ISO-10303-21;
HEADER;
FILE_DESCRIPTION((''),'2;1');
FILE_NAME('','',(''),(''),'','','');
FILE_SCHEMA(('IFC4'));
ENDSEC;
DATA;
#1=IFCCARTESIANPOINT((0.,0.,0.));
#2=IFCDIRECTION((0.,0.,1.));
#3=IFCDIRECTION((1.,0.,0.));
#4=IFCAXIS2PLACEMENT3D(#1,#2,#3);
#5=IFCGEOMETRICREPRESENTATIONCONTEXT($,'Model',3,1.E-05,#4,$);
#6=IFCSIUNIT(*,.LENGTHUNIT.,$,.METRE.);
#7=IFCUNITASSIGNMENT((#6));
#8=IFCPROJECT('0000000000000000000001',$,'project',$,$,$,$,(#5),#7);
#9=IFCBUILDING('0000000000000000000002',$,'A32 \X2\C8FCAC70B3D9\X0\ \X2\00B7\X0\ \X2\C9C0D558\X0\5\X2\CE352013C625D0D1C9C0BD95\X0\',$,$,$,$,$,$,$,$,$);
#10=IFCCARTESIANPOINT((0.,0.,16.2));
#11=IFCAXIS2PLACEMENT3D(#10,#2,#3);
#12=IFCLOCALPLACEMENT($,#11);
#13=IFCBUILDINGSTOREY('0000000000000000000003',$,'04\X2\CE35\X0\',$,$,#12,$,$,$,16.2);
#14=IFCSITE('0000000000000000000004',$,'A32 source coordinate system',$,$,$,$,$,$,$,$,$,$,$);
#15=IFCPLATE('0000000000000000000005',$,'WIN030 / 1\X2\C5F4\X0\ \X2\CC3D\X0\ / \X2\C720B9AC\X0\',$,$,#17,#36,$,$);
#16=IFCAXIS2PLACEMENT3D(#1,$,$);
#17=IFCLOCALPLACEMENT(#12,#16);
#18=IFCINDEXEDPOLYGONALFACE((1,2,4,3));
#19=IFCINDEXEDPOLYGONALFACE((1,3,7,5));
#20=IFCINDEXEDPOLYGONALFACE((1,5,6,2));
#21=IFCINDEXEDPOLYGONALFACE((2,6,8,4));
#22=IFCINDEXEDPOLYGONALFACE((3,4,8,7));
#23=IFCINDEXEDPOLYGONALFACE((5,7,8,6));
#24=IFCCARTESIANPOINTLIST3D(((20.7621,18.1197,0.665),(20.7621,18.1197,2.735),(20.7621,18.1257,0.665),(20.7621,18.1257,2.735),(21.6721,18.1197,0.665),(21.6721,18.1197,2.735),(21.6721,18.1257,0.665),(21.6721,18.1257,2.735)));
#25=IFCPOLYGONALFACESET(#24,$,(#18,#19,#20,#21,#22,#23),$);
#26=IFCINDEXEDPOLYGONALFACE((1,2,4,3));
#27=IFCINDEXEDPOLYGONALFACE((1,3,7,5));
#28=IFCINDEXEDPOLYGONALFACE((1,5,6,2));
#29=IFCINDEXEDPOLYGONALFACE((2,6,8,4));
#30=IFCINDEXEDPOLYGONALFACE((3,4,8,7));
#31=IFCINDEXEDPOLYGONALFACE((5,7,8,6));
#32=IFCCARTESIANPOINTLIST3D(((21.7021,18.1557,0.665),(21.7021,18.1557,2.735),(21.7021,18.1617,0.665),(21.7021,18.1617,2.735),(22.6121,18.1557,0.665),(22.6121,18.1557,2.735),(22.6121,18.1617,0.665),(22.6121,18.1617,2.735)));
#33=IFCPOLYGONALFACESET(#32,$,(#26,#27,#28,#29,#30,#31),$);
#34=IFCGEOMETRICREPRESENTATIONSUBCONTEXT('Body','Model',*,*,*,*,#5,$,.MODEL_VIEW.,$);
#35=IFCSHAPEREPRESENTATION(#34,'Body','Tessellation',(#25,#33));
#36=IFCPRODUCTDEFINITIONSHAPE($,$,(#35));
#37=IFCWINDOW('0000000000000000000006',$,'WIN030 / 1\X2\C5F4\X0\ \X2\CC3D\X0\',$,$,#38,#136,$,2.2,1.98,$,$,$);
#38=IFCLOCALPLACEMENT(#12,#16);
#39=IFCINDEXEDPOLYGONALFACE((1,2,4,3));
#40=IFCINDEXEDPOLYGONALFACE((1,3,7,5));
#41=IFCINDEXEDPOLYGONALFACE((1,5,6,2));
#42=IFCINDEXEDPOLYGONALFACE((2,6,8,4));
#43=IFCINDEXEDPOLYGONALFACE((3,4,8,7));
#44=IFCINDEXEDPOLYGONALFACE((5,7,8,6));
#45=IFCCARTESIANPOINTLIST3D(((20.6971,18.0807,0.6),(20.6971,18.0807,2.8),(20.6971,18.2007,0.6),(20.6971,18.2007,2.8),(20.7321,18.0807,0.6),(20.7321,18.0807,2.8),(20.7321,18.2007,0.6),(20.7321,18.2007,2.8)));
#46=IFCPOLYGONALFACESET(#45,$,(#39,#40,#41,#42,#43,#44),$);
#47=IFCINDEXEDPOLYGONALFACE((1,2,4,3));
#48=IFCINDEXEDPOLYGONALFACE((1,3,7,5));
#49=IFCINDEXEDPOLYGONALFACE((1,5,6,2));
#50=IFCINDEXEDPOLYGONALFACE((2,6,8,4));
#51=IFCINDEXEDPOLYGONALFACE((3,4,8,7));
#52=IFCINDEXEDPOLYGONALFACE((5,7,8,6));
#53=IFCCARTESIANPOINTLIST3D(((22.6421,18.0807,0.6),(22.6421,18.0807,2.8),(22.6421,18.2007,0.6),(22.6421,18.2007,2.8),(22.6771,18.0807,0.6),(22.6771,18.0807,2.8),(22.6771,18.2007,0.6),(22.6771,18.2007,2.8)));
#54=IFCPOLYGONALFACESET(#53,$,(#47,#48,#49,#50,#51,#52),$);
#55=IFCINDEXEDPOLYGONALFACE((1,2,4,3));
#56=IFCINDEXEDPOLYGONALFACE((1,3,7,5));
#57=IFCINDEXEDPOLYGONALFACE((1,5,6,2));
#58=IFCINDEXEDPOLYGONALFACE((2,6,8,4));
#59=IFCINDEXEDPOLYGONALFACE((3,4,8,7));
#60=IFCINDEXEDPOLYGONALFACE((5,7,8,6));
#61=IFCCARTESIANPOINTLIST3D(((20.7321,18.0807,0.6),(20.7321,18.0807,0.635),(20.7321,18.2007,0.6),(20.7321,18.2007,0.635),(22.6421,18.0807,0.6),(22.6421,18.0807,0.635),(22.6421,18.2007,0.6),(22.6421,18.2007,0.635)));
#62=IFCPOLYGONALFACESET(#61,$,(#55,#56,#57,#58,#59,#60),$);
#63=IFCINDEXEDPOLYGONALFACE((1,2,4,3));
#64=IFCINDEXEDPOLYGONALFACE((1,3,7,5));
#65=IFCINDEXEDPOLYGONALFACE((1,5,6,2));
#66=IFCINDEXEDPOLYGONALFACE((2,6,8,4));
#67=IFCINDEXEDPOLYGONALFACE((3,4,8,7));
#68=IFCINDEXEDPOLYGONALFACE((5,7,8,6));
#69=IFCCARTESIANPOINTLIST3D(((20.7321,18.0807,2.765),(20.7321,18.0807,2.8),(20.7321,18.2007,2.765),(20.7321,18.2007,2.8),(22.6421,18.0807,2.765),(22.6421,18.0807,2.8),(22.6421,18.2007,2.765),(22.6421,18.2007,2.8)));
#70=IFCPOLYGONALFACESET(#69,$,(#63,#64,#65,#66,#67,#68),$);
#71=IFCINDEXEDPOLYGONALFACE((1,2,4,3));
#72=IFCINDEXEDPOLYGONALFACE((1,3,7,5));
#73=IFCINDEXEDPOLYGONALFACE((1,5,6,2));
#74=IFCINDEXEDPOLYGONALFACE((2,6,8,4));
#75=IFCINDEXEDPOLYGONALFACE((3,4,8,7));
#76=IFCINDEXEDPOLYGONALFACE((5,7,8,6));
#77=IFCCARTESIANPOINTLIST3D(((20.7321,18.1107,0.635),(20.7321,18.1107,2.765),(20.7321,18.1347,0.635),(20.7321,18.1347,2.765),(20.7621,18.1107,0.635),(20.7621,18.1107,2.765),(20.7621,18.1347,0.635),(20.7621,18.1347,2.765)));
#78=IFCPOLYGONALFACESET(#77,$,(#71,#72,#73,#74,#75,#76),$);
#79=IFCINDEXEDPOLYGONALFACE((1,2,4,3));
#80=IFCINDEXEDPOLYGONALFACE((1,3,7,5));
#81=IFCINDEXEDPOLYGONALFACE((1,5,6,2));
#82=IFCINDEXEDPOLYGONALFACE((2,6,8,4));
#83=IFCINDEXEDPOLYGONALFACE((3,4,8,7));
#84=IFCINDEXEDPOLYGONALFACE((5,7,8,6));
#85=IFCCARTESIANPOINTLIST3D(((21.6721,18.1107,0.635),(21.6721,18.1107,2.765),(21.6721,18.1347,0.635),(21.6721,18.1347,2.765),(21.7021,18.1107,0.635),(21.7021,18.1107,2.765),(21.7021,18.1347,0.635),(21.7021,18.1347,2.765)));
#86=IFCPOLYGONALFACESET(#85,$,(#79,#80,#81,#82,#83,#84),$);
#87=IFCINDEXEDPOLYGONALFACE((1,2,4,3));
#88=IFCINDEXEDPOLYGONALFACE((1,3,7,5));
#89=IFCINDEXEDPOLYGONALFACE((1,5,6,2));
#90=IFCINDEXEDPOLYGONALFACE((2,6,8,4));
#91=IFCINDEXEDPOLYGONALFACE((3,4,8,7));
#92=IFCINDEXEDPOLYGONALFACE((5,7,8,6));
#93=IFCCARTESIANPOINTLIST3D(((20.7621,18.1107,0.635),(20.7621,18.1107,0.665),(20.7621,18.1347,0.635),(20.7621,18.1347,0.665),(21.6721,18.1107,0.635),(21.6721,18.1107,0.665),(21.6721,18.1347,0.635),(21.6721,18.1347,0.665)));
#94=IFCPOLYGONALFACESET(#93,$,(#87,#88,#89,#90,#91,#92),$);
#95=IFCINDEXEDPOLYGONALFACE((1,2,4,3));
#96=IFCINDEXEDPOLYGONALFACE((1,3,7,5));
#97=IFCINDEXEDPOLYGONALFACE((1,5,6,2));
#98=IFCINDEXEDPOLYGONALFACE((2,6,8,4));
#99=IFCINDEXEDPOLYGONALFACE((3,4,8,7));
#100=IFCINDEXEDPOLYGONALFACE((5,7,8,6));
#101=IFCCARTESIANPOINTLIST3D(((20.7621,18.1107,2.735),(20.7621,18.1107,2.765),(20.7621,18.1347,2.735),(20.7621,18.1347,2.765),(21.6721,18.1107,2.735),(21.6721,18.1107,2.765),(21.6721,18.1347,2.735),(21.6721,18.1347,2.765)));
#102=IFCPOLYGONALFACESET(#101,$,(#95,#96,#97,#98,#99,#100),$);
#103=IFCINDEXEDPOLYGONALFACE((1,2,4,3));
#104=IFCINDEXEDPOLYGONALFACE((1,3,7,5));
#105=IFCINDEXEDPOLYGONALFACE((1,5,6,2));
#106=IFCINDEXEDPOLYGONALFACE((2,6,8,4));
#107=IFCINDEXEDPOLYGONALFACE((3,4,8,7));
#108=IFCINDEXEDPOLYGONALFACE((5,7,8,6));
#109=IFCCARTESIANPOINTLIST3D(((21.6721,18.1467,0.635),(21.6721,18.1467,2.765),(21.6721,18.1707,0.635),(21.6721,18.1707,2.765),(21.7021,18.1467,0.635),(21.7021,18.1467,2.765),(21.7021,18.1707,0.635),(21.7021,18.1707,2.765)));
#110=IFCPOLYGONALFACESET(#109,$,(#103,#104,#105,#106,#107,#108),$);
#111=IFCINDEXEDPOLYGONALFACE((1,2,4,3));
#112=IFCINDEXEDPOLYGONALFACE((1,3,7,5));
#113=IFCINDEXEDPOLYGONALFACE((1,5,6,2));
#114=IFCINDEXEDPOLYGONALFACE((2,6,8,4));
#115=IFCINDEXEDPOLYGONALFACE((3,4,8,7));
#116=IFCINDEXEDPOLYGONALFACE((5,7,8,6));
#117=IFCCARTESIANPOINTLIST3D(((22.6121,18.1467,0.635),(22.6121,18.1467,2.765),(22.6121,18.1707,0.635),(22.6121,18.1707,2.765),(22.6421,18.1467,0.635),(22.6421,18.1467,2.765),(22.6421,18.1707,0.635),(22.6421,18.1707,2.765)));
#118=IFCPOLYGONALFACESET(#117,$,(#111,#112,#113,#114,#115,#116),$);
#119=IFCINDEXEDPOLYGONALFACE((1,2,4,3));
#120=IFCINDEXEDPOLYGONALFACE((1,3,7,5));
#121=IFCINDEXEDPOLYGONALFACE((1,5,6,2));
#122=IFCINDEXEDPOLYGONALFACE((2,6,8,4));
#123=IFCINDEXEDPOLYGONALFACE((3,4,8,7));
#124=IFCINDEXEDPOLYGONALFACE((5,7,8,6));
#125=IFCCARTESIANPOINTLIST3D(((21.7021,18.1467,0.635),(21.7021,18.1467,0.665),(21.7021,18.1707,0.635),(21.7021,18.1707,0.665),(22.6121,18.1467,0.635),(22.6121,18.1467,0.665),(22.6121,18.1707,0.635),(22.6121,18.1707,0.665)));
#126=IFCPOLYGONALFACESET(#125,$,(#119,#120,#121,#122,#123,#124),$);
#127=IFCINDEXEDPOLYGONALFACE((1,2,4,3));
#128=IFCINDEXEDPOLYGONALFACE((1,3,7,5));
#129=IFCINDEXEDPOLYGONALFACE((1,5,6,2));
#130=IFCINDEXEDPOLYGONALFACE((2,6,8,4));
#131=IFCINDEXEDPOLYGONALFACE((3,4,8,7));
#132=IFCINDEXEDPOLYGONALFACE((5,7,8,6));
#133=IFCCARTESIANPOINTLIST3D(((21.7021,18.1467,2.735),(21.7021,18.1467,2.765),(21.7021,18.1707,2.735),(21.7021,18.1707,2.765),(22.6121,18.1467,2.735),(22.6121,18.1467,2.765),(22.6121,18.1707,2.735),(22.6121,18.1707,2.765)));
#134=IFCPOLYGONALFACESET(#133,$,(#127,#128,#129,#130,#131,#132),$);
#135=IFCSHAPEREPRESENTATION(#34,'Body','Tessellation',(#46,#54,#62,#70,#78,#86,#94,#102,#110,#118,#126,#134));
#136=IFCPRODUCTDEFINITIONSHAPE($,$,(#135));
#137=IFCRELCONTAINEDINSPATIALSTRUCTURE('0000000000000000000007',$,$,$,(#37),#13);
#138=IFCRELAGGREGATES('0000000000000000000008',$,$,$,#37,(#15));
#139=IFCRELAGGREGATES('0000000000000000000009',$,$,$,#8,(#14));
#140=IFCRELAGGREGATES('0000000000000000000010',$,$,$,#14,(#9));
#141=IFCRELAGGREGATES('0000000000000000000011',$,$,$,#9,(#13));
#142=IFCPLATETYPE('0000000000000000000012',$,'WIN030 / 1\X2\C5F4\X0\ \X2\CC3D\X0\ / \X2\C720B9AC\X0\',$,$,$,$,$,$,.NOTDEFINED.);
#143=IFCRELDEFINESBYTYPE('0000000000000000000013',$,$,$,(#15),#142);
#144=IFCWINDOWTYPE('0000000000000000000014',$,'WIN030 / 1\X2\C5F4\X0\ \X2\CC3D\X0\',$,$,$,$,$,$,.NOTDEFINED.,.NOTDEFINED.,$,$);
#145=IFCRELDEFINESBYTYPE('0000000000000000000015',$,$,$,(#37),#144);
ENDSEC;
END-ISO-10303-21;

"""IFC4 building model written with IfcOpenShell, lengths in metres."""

from ifc_helpers import new_model, si_unit, frame, origin, origin_with_axes, place, context, subcontext, project, spatial, polyline, outline, extrude, source, transform, mapped, type_object, type_shapes, element, aggregate, save


model = new_model("IFC4")

# Units and contexts
model_context = context("Model", 3, precision=1e-05, world=origin_with_axes())
body_context = subcontext(model_context, "Body", "Model", "MODEL_VIEW")
ifc_project = project(units=[si_unit("LENGTHUNIT", "METRE")], contexts=[model_context])

# Plate
storey_placement = place(None, frame((0.0, 0.0, 16.2), z_axis=(0.0, 0.0, 1.0), x_axis=(1.0, 0.0, 0.0)))
plate_type_1 = type_object("IfcPlateType", Name="WIN030 / 1열 창 / 유리", PredefinedType="NOTDEFINED")
shared_shape_1 = source(origin(), body_context, "Body", "SweptSolid", [
    extrude(outline(polyline([(20.7621, 18.1197), (20.7621, 18.1257), (21.6721, 18.1257), (21.6721, 18.1197), (20.7621, 18.1197)])), frame((0.0, 0.0, 0.665)), (0.0, 0.0, 1.0), 2.07),
    extrude(outline(polyline([(21.7021, 18.1557), (21.7021, 18.1617), (22.6121, 18.1617), (22.6121, 18.1557), (21.7021, 18.1557)])), frame((0.0, 0.0, 0.665)), (0.0, 0.0, 1.0), 2.07),
])
type_shapes(plate_type_1, [shared_shape_1])
window_1_placement = place(storey_placement, origin_with_axes())
plate_1_placement = place(window_1_placement, origin_with_axes())
plate_1 = element("IfcPlate", 1, at=plate_1_placement, type_object=plate_type_1, Name="WIN030 / 1열 창 / 유리", context=body_context, shape_type="MappedRepresentation", body=[
    mapped(shared_shape_1, transform((0.0, 0.0, 0.0), scale=1.0)),
])

# Site, building, storey
site = spatial("IfcSite", under=ifc_project, Name="A32 source coordinate system")
building = spatial("IfcBuilding", under=site, Name="A32 주거동 · 지하5층–옥탑지붕")
storey = spatial("IfcBuildingStorey", under=building, at=storey_placement, Name="04층", Elevation=16.2)

# Window
window_type_1 = type_object("IfcWindowType", Name="WIN030 / 1열 창", PartitioningType="NOTDEFINED", PredefinedType="NOTDEFINED")
shared_shape_2 = source(origin(), body_context, "Body", "SweptSolid", [
    extrude(outline(polyline([(20.6971, 18.0807), (20.6971, 18.2007), (20.7321, 18.2007), (20.7321, 18.0807), (20.6971, 18.0807)])), frame((0.0, 0.0, 0.6)), (0.0, 0.0, 1.0), 2.2),
    extrude(outline(polyline([(22.6421, 18.0807), (22.6421, 18.2007), (22.6771, 18.2007), (22.6771, 18.0807), (22.6421, 18.0807)])), frame((0.0, 0.0, 0.6)), (0.0, 0.0, 1.0), 2.2),
    extrude(outline(polyline([(20.7321, 18.0807), (20.7321, 18.2007), (22.6421, 18.2007), (22.6421, 18.0807), (20.7321, 18.0807)])), frame((0.0, 0.0, 0.6)), (0.0, 0.0, 1.0), 0.035),
    extrude(outline(polyline([(20.7321, 18.0807), (20.7321, 18.2007), (22.6421, 18.2007), (22.6421, 18.0807), (20.7321, 18.0807)])), frame((0.0, 0.0, 2.765)), (0.0, 0.0, 1.0), 0.035),
    extrude(outline(polyline([(20.7321, 18.1107), (20.7321, 18.1347), (20.7621, 18.1347), (20.7621, 18.1107), (20.7321, 18.1107)])), frame((0.0, 0.0, 0.635)), (0.0, 0.0, 1.0), 2.13),
    extrude(outline(polyline([(21.6721, 18.1107), (21.6721, 18.1347), (21.7021, 18.1347), (21.7021, 18.1107), (21.6721, 18.1107)])), frame((0.0, 0.0, 0.635)), (0.0, 0.0, 1.0), 2.13),
    extrude(outline(polyline([(20.7621, 18.1107), (20.7621, 18.1347), (21.6721, 18.1347), (21.6721, 18.1107), (20.7621, 18.1107)])), frame((0.0, 0.0, 0.635)), (0.0, 0.0, 1.0), 0.03),
    extrude(outline(polyline([(20.7621, 18.1107), (20.7621, 18.1347), (21.6721, 18.1347), (21.6721, 18.1107), (20.7621, 18.1107)])), frame((0.0, 0.0, 2.735)), (0.0, 0.0, 1.0), 0.03),
    extrude(outline(polyline([(21.6721, 18.1467), (21.6721, 18.1707), (21.7021, 18.1707), (21.7021, 18.1467), (21.6721, 18.1467)])), frame((0.0, 0.0, 0.635)), (0.0, 0.0, 1.0), 2.13),
    extrude(outline(polyline([(22.6121, 18.1467), (22.6121, 18.1707), (22.6421, 18.1707), (22.6421, 18.1467), (22.6121, 18.1467)])), frame((0.0, 0.0, 0.635)), (0.0, 0.0, 1.0), 2.13),
    extrude(outline(polyline([(21.7021, 18.1467), (21.7021, 18.1707), (22.6121, 18.1707), (22.6121, 18.1467), (21.7021, 18.1467)])), frame((0.0, 0.0, 0.635)), (0.0, 0.0, 1.0), 0.03),
    extrude(outline(polyline([(21.7021, 18.1467), (21.7021, 18.1707), (22.6121, 18.1707), (22.6121, 18.1467), (21.7021, 18.1467)])), frame((0.0, 0.0, 2.735)), (0.0, 0.0, 1.0), 0.03),
])
type_shapes(window_type_1, [shared_shape_2])
window_1 = element("IfcWindow", 2, at=window_1_placement, inside=storey, type_object=window_type_1, Name="WIN030 / 1열 창", OverallHeight=2.2, OverallWidth=1.98, context=body_context, shape_type="MappedRepresentation", body=[
    mapped(shared_shape_2, transform((0.0, 0.0, 0.0), scale=1.0)),
])
aggregate(window_1, [plate_1])

save(model, "model.ifc")
